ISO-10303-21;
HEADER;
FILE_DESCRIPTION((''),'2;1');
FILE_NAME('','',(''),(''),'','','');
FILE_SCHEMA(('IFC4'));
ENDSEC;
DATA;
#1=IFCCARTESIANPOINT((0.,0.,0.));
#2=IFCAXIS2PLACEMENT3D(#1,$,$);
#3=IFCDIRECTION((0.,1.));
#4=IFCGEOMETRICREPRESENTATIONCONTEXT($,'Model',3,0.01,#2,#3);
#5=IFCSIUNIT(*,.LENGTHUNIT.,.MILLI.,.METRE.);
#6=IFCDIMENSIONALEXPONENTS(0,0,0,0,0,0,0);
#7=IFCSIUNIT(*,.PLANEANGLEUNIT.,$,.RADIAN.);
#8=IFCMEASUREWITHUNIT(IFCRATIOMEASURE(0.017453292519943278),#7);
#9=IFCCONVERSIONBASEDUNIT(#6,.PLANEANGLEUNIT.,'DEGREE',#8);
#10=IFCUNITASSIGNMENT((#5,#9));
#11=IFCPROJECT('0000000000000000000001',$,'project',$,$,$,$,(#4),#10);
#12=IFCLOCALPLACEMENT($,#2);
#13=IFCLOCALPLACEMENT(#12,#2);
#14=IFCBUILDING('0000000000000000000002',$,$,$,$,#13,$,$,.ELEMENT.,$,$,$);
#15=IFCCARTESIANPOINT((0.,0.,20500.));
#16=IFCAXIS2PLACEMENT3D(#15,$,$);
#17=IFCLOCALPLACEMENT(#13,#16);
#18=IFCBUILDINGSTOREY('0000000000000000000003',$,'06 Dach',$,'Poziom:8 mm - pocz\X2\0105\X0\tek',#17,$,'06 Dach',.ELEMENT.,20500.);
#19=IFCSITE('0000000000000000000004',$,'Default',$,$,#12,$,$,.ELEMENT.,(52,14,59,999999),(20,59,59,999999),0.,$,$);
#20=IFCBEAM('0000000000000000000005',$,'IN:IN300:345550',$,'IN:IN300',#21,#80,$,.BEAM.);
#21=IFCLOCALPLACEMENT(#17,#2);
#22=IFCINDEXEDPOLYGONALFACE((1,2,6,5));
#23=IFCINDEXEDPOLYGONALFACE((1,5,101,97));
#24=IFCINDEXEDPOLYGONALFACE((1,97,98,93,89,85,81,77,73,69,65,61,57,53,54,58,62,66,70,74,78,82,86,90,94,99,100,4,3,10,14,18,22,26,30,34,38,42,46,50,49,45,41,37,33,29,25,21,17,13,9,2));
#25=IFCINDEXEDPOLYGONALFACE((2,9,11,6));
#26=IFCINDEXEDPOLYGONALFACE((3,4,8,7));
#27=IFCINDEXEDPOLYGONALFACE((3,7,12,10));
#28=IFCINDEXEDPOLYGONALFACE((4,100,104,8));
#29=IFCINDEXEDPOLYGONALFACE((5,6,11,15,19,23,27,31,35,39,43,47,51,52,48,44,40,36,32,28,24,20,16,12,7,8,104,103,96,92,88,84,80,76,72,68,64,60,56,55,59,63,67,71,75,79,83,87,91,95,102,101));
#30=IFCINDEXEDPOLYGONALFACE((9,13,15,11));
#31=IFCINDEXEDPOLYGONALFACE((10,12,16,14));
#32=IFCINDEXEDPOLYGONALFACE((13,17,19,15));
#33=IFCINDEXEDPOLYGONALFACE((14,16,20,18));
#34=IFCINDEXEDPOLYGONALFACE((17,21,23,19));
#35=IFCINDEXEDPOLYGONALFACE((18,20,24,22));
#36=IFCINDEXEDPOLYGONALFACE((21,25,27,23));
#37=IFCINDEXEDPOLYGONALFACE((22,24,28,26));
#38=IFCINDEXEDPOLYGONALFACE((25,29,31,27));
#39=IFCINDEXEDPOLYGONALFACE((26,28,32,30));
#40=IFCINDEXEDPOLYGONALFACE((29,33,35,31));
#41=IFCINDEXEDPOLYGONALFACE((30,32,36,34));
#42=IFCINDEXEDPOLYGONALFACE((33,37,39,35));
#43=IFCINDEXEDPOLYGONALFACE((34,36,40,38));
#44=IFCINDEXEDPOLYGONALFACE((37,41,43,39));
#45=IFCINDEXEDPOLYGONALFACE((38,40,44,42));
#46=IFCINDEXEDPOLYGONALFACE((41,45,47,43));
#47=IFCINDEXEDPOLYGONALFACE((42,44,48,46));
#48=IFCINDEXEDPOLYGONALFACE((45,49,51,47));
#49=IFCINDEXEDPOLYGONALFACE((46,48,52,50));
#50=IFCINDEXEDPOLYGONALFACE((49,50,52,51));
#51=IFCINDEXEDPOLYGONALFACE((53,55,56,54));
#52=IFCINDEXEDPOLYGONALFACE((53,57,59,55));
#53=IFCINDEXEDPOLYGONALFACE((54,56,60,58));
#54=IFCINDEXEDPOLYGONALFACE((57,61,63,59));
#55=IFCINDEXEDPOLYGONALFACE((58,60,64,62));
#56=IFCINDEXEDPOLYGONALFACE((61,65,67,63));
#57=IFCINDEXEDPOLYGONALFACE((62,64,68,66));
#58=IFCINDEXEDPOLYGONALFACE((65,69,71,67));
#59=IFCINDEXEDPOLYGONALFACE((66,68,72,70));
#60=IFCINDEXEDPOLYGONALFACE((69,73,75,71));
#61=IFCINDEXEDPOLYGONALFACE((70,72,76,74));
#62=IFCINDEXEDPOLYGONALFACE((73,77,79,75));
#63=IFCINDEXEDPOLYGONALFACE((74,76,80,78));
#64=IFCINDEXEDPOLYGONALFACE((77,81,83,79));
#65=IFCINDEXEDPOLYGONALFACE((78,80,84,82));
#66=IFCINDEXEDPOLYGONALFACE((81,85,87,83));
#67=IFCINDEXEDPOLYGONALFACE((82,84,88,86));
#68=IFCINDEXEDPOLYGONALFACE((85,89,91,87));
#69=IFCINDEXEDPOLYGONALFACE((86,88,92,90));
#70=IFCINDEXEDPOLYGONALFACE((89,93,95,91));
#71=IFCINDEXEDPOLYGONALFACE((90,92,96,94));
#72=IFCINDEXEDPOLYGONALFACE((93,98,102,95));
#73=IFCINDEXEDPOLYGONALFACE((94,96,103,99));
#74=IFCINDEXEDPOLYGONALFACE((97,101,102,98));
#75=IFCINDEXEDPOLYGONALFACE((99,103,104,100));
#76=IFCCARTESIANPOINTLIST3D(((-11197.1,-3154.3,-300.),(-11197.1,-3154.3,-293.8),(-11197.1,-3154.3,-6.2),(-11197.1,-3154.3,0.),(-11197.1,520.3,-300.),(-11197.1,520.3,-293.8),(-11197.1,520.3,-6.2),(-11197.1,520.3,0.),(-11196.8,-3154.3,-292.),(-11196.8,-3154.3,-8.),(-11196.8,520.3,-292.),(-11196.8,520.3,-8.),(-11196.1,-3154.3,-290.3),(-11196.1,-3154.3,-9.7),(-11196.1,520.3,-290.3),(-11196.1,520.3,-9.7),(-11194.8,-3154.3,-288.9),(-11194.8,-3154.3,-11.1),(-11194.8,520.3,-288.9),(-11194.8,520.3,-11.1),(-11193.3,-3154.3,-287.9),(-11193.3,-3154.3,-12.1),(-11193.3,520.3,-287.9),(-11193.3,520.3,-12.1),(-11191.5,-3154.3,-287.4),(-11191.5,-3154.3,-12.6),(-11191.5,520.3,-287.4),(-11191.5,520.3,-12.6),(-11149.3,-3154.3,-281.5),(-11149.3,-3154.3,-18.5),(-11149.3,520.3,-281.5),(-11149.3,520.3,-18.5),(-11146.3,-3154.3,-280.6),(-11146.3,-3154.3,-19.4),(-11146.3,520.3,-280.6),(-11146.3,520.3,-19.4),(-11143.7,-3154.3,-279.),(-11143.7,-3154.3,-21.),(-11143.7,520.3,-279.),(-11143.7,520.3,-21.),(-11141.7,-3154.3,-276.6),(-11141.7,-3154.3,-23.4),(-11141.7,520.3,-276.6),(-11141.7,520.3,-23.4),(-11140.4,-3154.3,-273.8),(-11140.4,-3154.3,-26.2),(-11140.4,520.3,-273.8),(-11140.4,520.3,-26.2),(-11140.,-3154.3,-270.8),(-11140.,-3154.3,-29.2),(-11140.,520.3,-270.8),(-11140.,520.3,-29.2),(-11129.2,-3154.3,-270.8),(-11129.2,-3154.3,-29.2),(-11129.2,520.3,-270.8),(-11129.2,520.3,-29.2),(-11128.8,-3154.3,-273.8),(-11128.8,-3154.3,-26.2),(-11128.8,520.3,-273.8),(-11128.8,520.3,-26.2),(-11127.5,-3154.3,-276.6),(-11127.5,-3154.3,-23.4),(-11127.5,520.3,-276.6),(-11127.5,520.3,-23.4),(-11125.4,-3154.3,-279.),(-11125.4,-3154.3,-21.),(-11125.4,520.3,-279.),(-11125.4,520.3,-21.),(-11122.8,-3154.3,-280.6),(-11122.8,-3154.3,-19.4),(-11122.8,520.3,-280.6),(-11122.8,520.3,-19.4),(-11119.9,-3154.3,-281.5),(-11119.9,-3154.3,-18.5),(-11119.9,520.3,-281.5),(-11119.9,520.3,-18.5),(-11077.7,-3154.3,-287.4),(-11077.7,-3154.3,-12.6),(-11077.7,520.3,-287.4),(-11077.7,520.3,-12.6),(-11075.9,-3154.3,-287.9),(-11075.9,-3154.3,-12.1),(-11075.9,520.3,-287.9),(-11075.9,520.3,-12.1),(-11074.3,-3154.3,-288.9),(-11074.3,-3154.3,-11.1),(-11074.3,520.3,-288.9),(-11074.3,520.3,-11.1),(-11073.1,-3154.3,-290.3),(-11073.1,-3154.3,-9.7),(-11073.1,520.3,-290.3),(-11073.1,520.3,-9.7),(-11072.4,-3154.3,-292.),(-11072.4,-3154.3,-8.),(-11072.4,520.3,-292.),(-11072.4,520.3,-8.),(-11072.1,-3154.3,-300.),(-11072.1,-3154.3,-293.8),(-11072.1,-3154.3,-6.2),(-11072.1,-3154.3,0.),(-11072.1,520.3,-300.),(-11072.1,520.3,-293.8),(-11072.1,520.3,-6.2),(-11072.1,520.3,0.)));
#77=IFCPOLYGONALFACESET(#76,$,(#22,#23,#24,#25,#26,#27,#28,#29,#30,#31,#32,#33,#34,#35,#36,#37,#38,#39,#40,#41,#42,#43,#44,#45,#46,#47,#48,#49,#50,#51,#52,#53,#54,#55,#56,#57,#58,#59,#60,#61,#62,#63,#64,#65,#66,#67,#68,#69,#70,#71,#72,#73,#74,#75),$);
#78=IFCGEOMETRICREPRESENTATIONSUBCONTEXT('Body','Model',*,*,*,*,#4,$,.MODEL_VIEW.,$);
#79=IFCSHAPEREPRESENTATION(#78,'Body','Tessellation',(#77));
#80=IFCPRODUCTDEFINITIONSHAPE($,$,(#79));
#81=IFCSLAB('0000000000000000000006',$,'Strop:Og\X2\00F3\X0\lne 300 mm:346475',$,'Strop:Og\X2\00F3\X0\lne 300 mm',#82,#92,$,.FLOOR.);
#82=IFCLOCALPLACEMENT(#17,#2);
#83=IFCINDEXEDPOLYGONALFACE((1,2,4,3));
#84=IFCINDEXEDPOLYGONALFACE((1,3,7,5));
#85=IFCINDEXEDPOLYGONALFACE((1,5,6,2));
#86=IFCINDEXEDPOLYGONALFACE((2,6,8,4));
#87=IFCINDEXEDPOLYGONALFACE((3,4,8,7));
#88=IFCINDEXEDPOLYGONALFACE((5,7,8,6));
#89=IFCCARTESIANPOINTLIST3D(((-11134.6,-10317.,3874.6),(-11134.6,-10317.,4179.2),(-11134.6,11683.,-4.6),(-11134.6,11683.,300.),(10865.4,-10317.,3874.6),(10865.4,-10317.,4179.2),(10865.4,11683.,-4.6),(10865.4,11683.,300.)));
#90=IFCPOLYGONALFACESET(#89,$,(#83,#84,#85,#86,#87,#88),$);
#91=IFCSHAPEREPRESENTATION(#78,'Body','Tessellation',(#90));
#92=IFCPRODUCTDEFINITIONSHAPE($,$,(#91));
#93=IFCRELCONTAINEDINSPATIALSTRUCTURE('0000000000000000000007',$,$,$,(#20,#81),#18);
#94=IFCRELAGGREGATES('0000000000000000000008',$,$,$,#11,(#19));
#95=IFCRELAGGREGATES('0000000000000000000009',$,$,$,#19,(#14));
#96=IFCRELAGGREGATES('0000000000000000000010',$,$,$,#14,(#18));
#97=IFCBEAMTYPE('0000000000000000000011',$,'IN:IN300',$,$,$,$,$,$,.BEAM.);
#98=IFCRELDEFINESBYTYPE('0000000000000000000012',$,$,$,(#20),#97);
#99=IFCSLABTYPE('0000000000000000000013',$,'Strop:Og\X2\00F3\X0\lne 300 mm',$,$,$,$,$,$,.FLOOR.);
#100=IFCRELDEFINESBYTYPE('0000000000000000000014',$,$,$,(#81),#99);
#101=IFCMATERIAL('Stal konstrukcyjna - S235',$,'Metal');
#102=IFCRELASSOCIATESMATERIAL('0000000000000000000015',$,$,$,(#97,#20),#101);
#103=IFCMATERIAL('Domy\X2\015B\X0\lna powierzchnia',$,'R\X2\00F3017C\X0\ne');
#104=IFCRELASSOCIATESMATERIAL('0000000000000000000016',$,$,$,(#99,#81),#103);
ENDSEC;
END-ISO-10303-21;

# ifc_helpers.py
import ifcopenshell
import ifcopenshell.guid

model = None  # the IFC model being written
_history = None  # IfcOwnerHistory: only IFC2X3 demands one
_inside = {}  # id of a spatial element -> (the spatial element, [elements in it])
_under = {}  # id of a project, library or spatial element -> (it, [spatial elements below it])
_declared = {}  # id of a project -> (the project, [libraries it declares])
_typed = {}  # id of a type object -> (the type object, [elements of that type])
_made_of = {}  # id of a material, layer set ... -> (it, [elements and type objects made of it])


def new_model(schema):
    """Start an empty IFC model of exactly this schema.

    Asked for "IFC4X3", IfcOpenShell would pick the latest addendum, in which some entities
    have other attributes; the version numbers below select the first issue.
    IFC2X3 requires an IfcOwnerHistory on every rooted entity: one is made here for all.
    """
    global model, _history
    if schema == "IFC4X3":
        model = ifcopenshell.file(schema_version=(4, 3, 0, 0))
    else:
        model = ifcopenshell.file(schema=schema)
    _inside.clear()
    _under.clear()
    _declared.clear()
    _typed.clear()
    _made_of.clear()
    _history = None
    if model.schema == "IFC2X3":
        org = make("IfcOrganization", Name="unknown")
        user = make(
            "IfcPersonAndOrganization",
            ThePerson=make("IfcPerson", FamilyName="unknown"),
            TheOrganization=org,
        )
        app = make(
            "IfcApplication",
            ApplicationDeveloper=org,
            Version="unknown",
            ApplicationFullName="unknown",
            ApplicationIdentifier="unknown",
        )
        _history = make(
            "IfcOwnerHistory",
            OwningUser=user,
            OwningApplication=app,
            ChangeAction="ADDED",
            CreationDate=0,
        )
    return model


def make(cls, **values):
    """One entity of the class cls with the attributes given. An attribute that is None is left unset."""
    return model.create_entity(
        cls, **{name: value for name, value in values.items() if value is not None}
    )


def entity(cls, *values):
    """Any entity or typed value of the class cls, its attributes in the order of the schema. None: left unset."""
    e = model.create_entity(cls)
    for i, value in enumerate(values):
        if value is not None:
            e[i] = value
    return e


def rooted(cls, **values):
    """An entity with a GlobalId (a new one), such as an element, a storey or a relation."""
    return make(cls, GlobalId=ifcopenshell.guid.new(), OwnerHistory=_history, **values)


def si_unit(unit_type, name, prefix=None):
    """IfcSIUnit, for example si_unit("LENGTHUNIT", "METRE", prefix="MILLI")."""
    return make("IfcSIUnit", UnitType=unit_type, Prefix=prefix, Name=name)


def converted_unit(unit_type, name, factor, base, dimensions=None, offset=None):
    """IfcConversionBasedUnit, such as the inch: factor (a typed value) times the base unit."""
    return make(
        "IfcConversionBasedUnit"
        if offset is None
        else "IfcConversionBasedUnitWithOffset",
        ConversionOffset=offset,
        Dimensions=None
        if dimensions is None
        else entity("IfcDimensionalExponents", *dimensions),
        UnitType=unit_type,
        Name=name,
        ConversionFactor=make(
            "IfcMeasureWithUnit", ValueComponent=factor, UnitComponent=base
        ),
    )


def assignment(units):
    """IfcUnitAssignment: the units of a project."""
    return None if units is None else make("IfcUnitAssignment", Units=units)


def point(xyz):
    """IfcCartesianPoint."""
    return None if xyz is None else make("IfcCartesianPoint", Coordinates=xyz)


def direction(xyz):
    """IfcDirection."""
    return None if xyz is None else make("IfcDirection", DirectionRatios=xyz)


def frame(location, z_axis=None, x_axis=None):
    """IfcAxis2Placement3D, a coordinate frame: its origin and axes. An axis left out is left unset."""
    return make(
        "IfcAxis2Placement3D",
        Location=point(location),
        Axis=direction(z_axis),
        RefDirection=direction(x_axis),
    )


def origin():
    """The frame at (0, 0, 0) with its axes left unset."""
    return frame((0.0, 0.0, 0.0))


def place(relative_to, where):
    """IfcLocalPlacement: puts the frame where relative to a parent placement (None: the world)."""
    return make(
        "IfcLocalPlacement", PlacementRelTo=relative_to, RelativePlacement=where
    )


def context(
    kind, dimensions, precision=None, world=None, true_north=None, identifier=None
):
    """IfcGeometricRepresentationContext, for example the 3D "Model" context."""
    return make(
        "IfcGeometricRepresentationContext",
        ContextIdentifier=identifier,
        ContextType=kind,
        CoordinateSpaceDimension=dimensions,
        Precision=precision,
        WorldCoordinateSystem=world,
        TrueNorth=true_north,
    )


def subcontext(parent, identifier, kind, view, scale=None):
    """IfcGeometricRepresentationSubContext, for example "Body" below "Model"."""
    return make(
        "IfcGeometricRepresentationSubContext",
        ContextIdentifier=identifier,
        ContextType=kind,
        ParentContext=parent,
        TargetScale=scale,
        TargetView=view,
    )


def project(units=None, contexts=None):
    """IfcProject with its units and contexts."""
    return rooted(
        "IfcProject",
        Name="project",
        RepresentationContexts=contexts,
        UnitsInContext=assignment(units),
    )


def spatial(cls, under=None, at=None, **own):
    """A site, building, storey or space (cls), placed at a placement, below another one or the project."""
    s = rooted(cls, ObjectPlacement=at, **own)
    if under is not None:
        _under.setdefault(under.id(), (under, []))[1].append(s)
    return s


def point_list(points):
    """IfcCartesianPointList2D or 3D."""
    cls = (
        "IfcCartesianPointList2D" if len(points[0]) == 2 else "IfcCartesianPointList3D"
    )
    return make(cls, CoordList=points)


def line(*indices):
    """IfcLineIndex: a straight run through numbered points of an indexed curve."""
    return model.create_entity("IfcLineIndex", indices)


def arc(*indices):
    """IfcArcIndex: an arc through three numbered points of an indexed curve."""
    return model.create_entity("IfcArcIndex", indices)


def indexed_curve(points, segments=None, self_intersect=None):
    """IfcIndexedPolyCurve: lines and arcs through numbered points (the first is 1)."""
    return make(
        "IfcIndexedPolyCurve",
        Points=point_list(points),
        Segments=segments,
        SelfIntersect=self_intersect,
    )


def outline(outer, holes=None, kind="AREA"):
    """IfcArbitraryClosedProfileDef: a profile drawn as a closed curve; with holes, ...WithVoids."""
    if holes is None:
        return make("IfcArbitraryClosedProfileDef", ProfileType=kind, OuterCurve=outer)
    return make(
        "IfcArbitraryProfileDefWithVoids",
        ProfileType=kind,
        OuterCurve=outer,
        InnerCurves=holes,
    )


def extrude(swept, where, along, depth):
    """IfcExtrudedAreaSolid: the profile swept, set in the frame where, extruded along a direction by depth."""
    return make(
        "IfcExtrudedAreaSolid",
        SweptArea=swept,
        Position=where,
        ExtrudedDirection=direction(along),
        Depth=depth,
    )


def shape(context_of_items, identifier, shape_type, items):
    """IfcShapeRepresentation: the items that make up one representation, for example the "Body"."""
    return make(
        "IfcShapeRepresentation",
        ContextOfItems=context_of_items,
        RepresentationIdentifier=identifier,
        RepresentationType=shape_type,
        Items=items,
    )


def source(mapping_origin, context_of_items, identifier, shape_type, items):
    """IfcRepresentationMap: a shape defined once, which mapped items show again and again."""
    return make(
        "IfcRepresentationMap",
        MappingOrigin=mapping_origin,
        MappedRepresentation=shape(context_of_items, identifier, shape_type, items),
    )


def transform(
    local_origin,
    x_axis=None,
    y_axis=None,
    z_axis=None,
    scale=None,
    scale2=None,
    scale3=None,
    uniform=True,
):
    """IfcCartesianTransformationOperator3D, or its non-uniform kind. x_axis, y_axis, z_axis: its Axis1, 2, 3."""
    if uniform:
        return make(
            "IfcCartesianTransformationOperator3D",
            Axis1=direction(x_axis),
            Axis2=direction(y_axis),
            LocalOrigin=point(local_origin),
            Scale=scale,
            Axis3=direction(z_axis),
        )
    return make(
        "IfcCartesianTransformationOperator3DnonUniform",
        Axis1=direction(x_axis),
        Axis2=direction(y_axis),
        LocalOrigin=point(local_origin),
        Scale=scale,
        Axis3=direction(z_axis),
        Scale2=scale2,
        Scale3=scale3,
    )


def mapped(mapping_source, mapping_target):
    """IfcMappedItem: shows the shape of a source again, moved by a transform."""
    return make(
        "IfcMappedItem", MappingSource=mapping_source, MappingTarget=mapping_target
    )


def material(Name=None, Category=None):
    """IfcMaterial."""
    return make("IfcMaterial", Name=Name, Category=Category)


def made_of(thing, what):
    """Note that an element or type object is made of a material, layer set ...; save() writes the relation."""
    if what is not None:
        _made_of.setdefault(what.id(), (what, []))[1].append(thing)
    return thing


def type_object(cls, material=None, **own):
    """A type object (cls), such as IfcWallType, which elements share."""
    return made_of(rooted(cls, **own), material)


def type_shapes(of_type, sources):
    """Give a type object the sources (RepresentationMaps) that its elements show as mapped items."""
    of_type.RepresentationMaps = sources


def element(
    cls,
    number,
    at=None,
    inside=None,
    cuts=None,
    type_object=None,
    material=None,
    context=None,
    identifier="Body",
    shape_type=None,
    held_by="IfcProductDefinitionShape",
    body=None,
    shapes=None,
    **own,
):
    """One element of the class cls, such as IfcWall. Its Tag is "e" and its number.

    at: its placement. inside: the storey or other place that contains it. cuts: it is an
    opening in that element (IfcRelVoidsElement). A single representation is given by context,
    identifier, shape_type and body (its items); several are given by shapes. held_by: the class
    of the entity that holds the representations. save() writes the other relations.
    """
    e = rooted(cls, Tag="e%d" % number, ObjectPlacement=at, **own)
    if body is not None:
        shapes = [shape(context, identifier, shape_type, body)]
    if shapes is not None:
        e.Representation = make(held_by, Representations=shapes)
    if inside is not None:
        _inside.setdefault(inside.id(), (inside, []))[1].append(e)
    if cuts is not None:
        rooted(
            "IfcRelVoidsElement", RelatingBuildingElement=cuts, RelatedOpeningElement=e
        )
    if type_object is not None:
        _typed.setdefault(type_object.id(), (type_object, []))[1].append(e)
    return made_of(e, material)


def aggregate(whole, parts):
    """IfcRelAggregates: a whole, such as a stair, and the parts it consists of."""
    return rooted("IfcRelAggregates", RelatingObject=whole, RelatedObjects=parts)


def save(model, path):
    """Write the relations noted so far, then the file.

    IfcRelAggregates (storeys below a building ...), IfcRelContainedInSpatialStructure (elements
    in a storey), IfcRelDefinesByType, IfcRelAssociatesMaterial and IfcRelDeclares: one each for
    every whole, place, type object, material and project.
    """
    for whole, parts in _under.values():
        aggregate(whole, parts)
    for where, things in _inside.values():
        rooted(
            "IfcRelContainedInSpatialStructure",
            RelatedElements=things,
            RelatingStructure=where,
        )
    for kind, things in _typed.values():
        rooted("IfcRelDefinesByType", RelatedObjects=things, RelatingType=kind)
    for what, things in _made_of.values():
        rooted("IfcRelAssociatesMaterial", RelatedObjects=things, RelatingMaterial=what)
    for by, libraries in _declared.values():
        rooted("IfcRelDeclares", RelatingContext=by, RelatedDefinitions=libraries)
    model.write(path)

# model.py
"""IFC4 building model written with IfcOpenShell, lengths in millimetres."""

from ifc_helpers import new_model, entity, si_unit, converted_unit, direction, frame, origin, place, context, subcontext, project, spatial, line, arc, indexed_curve, outline, extrude, source, transform, mapped, material, type_object, type_shapes, element, save


model = new_model("IFC4")

# Units and contexts
model_context = context("Model", 3, precision=0.01, world=origin(), true_north=direction((0.0, 1.0)))
body_context = subcontext(model_context, "Body", "Model", "MODEL_VIEW")
ifc_project = project(units=[si_unit("LENGTHUNIT", "METRE", prefix="MILLI"), converted_unit("PLANEANGLEUNIT", "DEGREE", entity("IfcRatioMeasure", 0.017453292519943278), si_unit("PLANEANGLEUNIT", "RADIAN"), dimensions=[0, 0, 0, 0, 0, 0, 0])], contexts=[model_context])

# Site, building, storey
site_placement = place(None, origin())
site = spatial("IfcSite", under=ifc_project, at=site_placement, Name="Default", CompositionType="ELEMENT", RefLatitude=(52, 14, 59, 999999), RefLongitude=(20, 59, 59, 999999), RefElevation=0.0)
building_placement = place(site_placement, origin())
building = spatial("IfcBuilding", under=site, at=building_placement, CompositionType="ELEMENT")
storey_placement = place(building_placement, frame((0.0, 0.0, 20500.0)))
storey = spatial("IfcBuildingStorey", under=building, at=storey_placement, Name="06 Dach", ObjectType="Poziom:8 mm - początek", LongName="06 Dach", CompositionType="ELEMENT", Elevation=20500.0)

# Beam
ifc_material_1 = material(Name="Stal konstrukcyjna - S235", Category="Metal")
beam_type_1 = type_object("IfcBeamType", Name="IN:IN300", PredefinedType="BEAM", material=ifc_material_1)
shared_shape_1 = source(origin(), body_context, "Body", "SweptSolid", [
    extrude(outline(indexed_curve([(143.8, -62.5), (150.0, -62.5), (150.0, 62.5), (143.8, 62.5), (139.6, 60.9), (137.4, 56.9), (131.5, 14.7), (127.9, 8.1), (120.8, 5.4), (-120.8, 5.4), (-127.9, 8.1), (-131.5, 14.7), (-137.4, 56.9), (-139.6, 60.9), (-143.8, 62.5), (-150.0, 62.5), (-150.0, -62.5), (-143.8, -62.5), (-139.6, -60.9), (-137.4, -56.9), (-131.5, -14.7), (-127.9, -8.1), (-120.8, -5.4), (120.8, -5.4), (127.9, -8.1), (131.5, -14.7), (137.4, -56.9), (139.6, -60.9)], segments=[line(1, 2, 3, 4), arc(4, 5, 6), line(6, 7), arc(7, 8, 9), line(9, 10), arc(10, 11, 12), line(12, 13), arc(13, 14, 15), line(15, 16, 17, 18), arc(18, 19, 20), line(20, 21), arc(21, 22, 23), line(23, 24), arc(24, 25, 26), line(26, 27), arc(27, 28, 1)], self_intersect=False)), frame((-1837.3, 0.0, 0.0), z_axis=(1.0, 0.0, 0.0), x_axis=(0.0, 0.0, -1.0)), (0.0, 0.0, 1.0), 3674.6),
])
type_shapes(beam_type_1, [shared_shape_1])
for number, where, z_axis, x_axis, name in (
    (1, (-11134.6, -1317.0, -150.0), (0.0, 0.0, 1.0), (0.0, -1.0, 0.0), "IN:IN300:345550"),
):
    element("IfcBeam", number, at=place(storey_placement, frame(where, z_axis=z_axis, x_axis=x_axis)), inside=storey, type_object=beam_type_1, material=ifc_material_1, Name=name, ObjectType="IN:IN300", PredefinedType="BEAM", context=body_context, shape_type="MappedRepresentation", body=[
        mapped(shared_shape_1, transform((0.0, 0.0, 0.0), scale=1.0)),
    ])

# Slab
ifc_material_2 = material(Name="Domyślna powierzchnia", Category="Różne")
slab_type = type_object("IfcSlabType", Name="Strop:Ogólne 300 mm", PredefinedType="FLOOR", material=ifc_material_2)
slab_placement = place(storey_placement, origin())
element("IfcSlab", 2, at=slab_placement, inside=storey, type_object=slab_type, material=ifc_material_2, Name="Strop:Ogólne 300 mm:346475", ObjectType="Strop:Ogólne 300 mm", PredefinedType="FLOOR", context=body_context, shape_type="SweptSolid", body=[
    extrude(outline(indexed_curve([(-2091.9, -11000.0), (-1787.3, -11000.0), (2091.9, 11000.0), (1787.3, 11000.0), (-2091.9, -11000.0)], self_intersect=False)), frame((-11134.6, 683.0, 2087.3), z_axis=(1.0, 0.0, 0.0), x_axis=(0.0, 0.0, 1.0)), (0.0, 0.0, 1.0), 22000.0),
])

save(model, "model.ifc")
